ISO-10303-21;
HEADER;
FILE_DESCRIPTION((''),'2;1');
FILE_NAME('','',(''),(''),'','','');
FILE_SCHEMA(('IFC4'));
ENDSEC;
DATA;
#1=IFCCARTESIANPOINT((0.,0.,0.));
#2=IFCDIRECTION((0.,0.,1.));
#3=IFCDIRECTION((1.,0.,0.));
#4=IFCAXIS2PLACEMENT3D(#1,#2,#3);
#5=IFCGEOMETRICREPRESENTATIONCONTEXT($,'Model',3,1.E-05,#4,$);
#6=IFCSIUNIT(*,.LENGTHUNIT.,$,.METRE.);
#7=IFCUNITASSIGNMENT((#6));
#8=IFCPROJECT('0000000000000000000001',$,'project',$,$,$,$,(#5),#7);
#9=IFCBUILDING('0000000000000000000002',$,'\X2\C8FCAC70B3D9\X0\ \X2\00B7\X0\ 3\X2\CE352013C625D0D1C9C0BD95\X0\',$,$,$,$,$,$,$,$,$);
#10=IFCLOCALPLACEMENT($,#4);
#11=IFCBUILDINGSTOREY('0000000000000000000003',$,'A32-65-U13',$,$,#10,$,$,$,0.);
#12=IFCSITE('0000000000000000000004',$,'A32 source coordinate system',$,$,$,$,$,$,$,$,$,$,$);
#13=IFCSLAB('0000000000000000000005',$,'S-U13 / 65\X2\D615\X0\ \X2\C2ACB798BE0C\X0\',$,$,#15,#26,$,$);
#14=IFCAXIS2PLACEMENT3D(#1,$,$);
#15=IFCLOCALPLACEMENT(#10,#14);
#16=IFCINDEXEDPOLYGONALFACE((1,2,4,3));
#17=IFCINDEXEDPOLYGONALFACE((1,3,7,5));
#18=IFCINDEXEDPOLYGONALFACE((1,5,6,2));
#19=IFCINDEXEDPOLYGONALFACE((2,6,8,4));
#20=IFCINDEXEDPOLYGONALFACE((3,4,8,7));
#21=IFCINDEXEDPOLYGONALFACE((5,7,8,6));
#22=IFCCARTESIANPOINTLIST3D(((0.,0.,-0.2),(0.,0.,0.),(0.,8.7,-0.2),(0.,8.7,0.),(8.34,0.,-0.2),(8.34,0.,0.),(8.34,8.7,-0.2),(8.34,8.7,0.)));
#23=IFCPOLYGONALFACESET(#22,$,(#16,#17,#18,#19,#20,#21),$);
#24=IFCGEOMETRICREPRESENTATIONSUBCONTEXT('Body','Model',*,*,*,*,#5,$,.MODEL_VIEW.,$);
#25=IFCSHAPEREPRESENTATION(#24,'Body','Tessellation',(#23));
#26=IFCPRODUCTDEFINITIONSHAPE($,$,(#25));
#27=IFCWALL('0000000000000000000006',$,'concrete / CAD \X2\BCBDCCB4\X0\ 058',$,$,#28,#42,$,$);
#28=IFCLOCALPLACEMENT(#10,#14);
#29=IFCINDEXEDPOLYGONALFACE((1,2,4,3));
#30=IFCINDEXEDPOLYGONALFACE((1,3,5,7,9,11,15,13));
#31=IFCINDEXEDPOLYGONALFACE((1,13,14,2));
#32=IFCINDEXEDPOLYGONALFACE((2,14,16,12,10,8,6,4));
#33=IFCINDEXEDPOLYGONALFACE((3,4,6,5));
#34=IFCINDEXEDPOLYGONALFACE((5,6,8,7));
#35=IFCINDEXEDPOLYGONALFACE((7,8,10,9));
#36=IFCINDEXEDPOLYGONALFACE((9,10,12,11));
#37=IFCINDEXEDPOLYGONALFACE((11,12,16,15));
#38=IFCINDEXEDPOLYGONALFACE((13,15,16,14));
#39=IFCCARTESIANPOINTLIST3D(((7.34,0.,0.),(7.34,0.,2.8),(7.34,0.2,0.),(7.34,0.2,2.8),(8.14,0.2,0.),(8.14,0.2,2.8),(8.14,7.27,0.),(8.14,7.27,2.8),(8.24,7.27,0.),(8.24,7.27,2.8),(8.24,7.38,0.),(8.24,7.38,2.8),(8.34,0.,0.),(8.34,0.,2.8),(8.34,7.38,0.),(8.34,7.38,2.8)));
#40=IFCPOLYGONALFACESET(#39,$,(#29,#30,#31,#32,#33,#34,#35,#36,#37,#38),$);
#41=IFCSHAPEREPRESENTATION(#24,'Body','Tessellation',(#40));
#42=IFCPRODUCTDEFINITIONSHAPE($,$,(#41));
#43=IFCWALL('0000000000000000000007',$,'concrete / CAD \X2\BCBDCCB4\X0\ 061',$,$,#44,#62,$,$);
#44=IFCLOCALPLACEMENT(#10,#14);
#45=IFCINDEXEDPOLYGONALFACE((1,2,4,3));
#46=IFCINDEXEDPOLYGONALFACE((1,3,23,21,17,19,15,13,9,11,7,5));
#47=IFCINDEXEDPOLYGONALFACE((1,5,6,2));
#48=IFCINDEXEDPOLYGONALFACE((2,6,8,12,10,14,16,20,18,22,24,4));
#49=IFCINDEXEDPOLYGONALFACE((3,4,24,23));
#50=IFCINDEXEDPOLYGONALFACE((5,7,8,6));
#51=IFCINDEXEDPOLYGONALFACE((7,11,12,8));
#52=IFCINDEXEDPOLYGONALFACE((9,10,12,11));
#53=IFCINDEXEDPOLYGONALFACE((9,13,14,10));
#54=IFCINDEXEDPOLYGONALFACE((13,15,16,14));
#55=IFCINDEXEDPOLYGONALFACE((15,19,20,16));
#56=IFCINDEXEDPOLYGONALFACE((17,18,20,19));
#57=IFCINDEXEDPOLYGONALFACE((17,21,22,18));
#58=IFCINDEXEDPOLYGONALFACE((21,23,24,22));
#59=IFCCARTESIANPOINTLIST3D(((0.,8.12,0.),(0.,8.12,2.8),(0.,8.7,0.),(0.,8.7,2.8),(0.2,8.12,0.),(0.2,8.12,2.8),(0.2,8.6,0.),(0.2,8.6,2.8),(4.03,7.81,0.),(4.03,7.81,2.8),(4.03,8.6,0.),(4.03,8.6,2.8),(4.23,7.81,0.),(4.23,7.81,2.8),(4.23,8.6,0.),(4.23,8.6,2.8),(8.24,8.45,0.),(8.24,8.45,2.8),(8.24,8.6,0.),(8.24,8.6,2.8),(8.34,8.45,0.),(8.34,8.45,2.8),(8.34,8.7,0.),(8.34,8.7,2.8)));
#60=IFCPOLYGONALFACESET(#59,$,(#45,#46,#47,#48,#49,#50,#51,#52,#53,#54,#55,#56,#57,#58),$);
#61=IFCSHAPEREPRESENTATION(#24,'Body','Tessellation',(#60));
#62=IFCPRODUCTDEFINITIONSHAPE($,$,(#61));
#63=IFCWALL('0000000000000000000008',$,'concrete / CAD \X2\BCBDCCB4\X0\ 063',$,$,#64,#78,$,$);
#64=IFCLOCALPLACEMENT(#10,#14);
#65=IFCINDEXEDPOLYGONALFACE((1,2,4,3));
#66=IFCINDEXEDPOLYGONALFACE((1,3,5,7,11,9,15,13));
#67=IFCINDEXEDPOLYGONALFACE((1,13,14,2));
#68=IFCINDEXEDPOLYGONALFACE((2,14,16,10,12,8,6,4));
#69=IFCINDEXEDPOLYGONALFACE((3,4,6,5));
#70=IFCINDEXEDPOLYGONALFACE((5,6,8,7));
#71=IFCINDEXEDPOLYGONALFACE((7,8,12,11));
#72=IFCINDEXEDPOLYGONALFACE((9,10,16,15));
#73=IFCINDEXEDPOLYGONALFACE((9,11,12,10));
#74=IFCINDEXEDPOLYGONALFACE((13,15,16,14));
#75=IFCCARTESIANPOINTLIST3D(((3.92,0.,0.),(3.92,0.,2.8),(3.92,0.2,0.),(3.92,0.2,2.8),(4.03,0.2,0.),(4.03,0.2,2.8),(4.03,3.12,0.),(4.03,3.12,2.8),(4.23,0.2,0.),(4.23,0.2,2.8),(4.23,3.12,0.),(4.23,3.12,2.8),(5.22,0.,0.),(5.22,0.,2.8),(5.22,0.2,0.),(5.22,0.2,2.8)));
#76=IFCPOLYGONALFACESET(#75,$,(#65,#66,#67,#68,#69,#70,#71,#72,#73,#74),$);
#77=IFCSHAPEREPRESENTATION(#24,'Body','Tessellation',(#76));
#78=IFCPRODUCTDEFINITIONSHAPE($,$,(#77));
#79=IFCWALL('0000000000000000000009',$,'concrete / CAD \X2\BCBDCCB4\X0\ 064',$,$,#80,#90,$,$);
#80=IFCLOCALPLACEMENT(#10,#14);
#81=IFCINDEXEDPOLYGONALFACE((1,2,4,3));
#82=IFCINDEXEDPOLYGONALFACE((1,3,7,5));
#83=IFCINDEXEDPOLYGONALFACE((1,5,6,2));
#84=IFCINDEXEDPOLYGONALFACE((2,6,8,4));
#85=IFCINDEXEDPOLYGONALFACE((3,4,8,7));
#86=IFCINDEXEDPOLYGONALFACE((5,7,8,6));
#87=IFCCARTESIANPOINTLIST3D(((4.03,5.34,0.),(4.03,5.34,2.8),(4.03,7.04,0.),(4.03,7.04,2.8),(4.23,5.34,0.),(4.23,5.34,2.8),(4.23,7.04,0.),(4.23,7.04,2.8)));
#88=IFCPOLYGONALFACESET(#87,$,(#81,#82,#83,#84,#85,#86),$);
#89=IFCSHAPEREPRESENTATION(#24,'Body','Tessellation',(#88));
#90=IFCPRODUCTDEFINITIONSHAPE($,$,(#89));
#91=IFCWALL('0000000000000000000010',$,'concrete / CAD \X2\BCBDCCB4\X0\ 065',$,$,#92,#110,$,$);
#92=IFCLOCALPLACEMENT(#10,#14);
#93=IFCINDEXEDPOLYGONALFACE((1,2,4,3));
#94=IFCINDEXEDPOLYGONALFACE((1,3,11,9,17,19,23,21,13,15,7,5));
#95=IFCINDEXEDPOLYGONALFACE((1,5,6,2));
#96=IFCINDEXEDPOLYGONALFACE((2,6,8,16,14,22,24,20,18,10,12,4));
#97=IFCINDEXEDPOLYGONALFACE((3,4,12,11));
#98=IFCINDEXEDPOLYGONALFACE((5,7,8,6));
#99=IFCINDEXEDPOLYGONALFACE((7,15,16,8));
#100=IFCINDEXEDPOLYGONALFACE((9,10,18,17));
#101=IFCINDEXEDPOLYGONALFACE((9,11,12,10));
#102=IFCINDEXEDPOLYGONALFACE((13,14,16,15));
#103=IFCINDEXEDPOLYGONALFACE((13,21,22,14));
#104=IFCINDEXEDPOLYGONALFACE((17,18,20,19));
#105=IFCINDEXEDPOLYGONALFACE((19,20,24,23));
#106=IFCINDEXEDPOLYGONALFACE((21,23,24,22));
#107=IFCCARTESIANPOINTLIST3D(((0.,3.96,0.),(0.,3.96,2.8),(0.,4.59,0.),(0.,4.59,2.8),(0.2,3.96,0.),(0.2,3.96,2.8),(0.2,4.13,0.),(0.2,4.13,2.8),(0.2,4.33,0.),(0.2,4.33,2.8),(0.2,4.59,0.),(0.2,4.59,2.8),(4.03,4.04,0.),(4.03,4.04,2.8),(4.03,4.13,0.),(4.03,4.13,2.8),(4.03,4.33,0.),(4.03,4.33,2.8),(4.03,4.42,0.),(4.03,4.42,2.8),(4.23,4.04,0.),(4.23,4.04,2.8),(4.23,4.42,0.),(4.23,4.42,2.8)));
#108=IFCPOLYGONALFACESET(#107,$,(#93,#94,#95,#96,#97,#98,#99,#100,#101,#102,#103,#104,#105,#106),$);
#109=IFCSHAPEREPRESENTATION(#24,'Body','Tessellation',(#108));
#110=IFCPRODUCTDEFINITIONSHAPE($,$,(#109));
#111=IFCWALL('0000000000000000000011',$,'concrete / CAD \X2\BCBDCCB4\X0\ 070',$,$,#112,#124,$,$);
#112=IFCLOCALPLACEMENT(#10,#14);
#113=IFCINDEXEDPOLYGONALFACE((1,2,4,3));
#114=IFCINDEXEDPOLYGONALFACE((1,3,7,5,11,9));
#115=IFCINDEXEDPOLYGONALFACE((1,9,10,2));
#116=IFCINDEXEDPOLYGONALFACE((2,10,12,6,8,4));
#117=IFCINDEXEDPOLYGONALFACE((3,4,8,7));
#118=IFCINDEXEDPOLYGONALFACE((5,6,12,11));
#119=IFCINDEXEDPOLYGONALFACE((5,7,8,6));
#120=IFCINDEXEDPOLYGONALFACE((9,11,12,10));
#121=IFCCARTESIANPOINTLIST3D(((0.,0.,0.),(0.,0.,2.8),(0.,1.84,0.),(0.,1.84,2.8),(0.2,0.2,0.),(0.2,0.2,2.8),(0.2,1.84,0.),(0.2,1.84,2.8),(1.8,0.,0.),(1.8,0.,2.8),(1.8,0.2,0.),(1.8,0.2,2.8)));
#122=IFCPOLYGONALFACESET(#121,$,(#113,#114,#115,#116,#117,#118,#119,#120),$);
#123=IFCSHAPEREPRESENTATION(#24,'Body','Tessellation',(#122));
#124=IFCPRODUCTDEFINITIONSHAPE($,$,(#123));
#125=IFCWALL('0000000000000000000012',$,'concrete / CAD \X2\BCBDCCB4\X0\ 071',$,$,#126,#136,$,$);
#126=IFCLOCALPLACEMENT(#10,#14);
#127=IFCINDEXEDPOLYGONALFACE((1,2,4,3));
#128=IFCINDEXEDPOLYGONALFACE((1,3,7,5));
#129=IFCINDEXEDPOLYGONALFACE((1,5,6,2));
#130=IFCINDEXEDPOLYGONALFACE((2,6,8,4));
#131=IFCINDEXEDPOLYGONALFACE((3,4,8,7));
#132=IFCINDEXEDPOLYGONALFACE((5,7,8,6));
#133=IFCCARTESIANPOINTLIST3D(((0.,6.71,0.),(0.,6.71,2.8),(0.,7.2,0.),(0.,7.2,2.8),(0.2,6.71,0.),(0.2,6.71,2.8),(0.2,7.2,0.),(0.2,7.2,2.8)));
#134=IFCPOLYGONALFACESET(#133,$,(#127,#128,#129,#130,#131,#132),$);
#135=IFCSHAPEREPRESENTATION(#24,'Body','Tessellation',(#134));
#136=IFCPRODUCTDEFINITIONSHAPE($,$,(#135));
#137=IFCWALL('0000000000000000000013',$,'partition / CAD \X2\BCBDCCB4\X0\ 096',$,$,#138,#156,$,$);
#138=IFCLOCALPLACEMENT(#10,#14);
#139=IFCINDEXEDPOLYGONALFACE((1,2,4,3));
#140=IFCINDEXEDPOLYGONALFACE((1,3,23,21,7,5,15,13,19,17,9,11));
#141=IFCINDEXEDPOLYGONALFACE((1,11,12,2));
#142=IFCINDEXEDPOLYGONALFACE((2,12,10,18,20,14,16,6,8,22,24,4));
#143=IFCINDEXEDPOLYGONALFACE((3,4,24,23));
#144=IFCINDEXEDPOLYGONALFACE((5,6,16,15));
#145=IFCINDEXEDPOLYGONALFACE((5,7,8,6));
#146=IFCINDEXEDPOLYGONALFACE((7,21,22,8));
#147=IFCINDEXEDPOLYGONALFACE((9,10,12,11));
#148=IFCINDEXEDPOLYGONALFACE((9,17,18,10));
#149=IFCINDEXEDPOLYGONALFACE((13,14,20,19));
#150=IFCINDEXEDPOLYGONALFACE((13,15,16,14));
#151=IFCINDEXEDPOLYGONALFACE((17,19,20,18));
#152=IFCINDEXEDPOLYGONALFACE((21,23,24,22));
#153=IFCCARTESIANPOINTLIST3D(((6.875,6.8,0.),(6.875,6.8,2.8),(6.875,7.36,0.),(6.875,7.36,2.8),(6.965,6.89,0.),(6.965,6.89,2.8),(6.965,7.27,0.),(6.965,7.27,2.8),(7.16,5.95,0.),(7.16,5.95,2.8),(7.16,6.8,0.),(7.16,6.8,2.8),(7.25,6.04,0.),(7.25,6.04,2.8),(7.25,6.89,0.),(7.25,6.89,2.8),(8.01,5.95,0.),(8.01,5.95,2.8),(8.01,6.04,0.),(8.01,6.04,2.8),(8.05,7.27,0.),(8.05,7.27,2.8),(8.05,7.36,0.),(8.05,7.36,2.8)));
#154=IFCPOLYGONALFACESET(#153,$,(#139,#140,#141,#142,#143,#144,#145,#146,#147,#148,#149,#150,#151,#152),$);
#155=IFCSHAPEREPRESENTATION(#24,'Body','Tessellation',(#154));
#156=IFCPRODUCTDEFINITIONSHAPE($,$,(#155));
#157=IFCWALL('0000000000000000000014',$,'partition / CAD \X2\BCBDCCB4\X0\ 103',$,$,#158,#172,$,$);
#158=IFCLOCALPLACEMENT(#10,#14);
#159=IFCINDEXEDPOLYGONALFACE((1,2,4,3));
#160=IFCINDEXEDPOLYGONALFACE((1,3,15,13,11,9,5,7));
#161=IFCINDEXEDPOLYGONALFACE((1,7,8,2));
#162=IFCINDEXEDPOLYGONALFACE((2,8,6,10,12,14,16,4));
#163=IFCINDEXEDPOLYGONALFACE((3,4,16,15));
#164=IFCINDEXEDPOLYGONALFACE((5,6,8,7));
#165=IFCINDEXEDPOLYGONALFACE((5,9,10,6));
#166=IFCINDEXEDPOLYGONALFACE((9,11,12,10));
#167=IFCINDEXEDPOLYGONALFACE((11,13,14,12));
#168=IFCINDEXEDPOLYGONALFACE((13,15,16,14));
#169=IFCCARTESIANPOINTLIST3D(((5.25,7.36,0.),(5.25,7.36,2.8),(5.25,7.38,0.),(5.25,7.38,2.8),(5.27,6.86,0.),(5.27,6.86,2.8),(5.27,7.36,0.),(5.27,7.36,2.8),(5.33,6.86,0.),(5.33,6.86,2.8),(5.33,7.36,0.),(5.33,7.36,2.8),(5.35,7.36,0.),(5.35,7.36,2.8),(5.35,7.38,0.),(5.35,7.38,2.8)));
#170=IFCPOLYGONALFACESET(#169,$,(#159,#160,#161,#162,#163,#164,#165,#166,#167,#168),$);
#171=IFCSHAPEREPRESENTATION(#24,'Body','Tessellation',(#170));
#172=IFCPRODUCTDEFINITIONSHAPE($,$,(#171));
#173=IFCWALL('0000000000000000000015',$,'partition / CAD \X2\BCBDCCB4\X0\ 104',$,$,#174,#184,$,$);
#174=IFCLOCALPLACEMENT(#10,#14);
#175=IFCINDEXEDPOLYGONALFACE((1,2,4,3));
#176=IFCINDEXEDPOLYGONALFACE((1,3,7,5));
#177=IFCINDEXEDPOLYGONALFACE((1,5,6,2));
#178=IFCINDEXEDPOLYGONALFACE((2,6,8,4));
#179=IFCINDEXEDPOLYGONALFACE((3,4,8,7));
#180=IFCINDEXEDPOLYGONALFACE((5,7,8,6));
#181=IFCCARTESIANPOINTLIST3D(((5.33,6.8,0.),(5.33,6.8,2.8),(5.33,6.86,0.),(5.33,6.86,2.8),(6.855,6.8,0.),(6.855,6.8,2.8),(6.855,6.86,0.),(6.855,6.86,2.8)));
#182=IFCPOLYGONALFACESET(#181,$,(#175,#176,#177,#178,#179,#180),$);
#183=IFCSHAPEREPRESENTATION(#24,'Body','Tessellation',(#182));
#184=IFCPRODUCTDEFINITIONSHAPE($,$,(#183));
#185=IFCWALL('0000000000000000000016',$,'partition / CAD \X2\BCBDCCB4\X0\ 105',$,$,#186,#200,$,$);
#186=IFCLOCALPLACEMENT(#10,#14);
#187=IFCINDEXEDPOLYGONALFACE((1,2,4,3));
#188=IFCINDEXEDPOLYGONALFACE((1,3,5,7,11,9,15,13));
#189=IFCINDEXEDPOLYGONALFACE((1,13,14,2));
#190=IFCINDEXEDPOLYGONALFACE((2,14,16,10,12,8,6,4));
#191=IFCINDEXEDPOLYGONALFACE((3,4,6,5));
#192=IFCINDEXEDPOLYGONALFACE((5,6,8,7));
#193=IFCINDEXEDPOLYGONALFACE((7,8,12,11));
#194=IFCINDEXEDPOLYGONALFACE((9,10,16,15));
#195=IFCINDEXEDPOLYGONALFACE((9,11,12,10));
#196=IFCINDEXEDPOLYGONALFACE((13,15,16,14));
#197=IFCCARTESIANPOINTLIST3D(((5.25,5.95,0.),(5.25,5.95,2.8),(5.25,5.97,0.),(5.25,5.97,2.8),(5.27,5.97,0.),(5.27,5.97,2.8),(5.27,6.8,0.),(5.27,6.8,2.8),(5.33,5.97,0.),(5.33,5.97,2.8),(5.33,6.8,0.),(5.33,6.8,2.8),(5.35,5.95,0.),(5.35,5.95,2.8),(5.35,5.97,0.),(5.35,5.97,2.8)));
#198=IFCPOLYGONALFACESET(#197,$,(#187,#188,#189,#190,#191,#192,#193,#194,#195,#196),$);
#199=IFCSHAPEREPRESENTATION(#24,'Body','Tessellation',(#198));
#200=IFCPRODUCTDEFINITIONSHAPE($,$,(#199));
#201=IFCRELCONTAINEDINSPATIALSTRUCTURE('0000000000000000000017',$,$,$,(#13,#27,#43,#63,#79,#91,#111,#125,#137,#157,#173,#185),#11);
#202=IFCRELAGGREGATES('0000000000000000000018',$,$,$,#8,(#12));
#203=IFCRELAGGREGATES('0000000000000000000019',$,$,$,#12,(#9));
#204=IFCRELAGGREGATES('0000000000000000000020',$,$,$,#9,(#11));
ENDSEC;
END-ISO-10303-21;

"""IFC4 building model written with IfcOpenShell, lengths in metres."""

from ifc_helpers import new_model, si_unit, frame, origin, origin_with_axes, place, context, subcontext, project, spatial, polyline, outline, extrude, element, save


model = new_model("IFC4")

# Units and contexts
model_context = context("Model", 3, precision=1e-05, world=origin_with_axes())
body_context = subcontext(model_context, "Body", "Model", "MODEL_VIEW")
ifc_project = project(units=[si_unit("LENGTHUNIT", "METRE")], contexts=[model_context])

# Site, building, storey
site = spatial("IfcSite", under=ifc_project, Name="A32 source coordinate system")
building = spatial("IfcBuilding", under=site, Name="주거동 · 3층–옥탑지붕")
storey_placement = place(None, origin_with_axes())
storey = spatial("IfcBuildingStorey", under=building, at=storey_placement, Name="A32-65-U13", Elevation=0.0)

# Slab
slab_placement = place(storey_placement, origin_with_axes())
element("IfcSlab", 1, at=slab_placement, inside=storey, Name="S-U13 / 65형 슬래브", context=body_context, shape_type="SweptSolid", body=[
    extrude(outline(polyline([(0.0, 0.0), (0.0, 8.7), (8.34, 8.7), (8.34, 0.0), (0.0, 0.0)])), frame((0.0, 0.0, -0.2)), (0.0, 0.0, 1.0), 0.2),
])

# Walls
wall_1_placement = place(storey_placement, origin_with_axes())
element("IfcWall", 2, at=wall_1_placement, inside=storey, Name="concrete / CAD 벽체 058", context=body_context, shape_type="SweptSolid", body=[
    extrude(outline(polyline([(8.34, 0.0), (7.34, 0.0), (7.34, 0.2), (8.14, 0.2), (8.14, 7.27), (8.24, 7.27), (8.24, 7.38), (8.34, 7.38), (8.34, 0.0)])), origin(), (0.0, 0.0, 1.0), 2.8),
])
wall_2_placement = place(storey_placement, origin_with_axes())
element("IfcWall", 3, at=wall_2_placement, inside=storey, Name="concrete / CAD 벽체 061", context=body_context, shape_type="SweptSolid", body=[
    extrude(outline(polyline([(0.2, 8.6), (0.2, 8.12), (0.0, 8.12), (0.0, 8.7), (8.34, 8.7), (8.34, 8.45), (8.24, 8.45), (8.24, 8.6), (4.23, 8.6), (4.23, 7.81), (4.03, 7.81), (4.03, 8.6), (0.2, 8.6)])), origin(), (0.0, 0.0, 1.0), 2.8),
])
wall_3_placement = place(storey_placement, origin_with_axes())
element("IfcWall", 4, at=wall_3_placement, inside=storey, Name="concrete / CAD 벽체 063", context=body_context, shape_type="SweptSolid", body=[
    extrude(outline(polyline([(5.22, 0.0), (3.92, 0.0), (3.92, 0.2), (4.03, 0.2), (4.03, 3.12), (4.23, 3.12), (4.23, 0.2), (5.22, 0.2), (5.22, 0.0)])), origin(), (0.0, 0.0, 1.0), 2.8),
])
wall_4_placement = place(storey_placement, origin_with_axes())
element("IfcWall", 5, at=wall_4_placement, inside=storey, Name="concrete / CAD 벽체 064", context=body_context, shape_type="SweptSolid", body=[
    extrude(outline(polyline([(4.03, 7.04), (4.23, 7.04), (4.23, 5.34), (4.03, 5.34), (4.03, 7.04)])), origin(), (0.0, 0.0, 1.0), 2.8),
])
wall_5_placement = place(storey_placement, origin_with_axes())
element("IfcWall", 6, at=wall_5_placement, inside=storey, Name="concrete / CAD 벽체 065", context=body_context, shape_type="SweptSolid", body=[
    extrude(outline(polyline([(0.2, 4.59), (0.2, 4.33), (4.03, 4.33), (4.03, 4.42), (4.23, 4.42), (4.23, 4.04), (4.03, 4.04), (4.03, 4.13), (0.2, 4.13), (0.2, 3.96), (0.0, 3.96), (0.0, 4.59), (0.2, 4.59)])), origin(), (0.0, 0.0, 1.0), 2.8),
])
wall_6_placement = place(storey_placement, origin_with_axes())
element("IfcWall", 7, at=wall_6_placement, inside=storey, Name="concrete / CAD 벽체 070", context=body_context, shape_type="SweptSolid", body=[
    extrude(outline(polyline([(0.2, 1.84), (0.2, 0.2), (1.8, 0.2), (1.8, 0.0), (0.0, 0.0), (0.0, 1.84), (0.2, 1.84)])), origin(), (0.0, 0.0, 1.0), 2.8),
])
wall_7_placement = place(storey_placement, origin_with_axes())
element("IfcWall", 8, at=wall_7_placement, inside=storey, Name="concrete / CAD 벽체 071", context=body_context, shape_type="SweptSolid", body=[
    extrude(outline(polyline([(0.2, 6.71), (0.0, 6.71), (0.0, 7.2), (0.2, 7.2), (0.2, 6.71)])), origin(), (0.0, 0.0, 1.0), 2.8),
])
wall_8_placement = place(storey_placement, origin_with_axes())
element("IfcWall", 9, at=wall_8_placement, inside=storey, Name="partition / CAD 벽체 096", context=body_context, shape_type="SweptSolid", body=[
    extrude(outline(polyline([(7.25, 6.04), (8.01, 6.04), (8.01, 5.95), (7.16, 5.95), (7.16, 6.8), (6.875, 6.8), (6.875, 7.36), (8.05, 7.36), (8.05, 7.27), (6.965, 7.27), (6.965, 6.89), (7.25, 6.89), (7.25, 6.04)])), origin(), (0.0, 0.0, 1.0), 2.8),
])
wall_9_placement = place(storey_placement, origin_with_axes())
element("IfcWall", 10, at=wall_9_placement, inside=storey, Name="partition / CAD 벽체 103", context=body_context, shape_type="SweptSolid", body=[
    extrude(outline(polyline([(5.27, 7.36), (5.25, 7.36), (5.25, 7.38), (5.35, 7.38), (5.35, 7.36), (5.33, 7.36), (5.33, 6.86), (5.27, 6.86), (5.27, 7.36)])), origin(), (0.0, 0.0, 1.0), 2.8),
])
wall_10_placement = place(storey_placement, origin_with_axes())
element("IfcWall", 11, at=wall_10_placement, inside=storey, Name="partition / CAD 벽체 104", context=body_context, shape_type="SweptSolid", body=[
    extrude(outline(polyline([(6.855, 6.86), (6.855, 6.8), (5.33, 6.8), (5.33, 6.86), (6.855, 6.86)])), origin(), (0.0, 0.0, 1.0), 2.8),
])
wall_11_placement = place(storey_placement, origin_with_axes())
element("IfcWall", 12, at=wall_11_placement, inside=storey, Name="partition / CAD 벽체 105", context=body_context, shape_type="SweptSolid", body=[
    extrude(outline(polyline([(5.25, 5.97), (5.27, 5.97), (5.27, 6.8), (5.33, 6.8), (5.33, 5.97), (5.35, 5.97), (5.35, 5.95), (5.25, 5.95), (5.25, 5.97)])), origin(), (0.0, 0.0, 1.0), 2.8),
])

save(model, "model.ifc")
